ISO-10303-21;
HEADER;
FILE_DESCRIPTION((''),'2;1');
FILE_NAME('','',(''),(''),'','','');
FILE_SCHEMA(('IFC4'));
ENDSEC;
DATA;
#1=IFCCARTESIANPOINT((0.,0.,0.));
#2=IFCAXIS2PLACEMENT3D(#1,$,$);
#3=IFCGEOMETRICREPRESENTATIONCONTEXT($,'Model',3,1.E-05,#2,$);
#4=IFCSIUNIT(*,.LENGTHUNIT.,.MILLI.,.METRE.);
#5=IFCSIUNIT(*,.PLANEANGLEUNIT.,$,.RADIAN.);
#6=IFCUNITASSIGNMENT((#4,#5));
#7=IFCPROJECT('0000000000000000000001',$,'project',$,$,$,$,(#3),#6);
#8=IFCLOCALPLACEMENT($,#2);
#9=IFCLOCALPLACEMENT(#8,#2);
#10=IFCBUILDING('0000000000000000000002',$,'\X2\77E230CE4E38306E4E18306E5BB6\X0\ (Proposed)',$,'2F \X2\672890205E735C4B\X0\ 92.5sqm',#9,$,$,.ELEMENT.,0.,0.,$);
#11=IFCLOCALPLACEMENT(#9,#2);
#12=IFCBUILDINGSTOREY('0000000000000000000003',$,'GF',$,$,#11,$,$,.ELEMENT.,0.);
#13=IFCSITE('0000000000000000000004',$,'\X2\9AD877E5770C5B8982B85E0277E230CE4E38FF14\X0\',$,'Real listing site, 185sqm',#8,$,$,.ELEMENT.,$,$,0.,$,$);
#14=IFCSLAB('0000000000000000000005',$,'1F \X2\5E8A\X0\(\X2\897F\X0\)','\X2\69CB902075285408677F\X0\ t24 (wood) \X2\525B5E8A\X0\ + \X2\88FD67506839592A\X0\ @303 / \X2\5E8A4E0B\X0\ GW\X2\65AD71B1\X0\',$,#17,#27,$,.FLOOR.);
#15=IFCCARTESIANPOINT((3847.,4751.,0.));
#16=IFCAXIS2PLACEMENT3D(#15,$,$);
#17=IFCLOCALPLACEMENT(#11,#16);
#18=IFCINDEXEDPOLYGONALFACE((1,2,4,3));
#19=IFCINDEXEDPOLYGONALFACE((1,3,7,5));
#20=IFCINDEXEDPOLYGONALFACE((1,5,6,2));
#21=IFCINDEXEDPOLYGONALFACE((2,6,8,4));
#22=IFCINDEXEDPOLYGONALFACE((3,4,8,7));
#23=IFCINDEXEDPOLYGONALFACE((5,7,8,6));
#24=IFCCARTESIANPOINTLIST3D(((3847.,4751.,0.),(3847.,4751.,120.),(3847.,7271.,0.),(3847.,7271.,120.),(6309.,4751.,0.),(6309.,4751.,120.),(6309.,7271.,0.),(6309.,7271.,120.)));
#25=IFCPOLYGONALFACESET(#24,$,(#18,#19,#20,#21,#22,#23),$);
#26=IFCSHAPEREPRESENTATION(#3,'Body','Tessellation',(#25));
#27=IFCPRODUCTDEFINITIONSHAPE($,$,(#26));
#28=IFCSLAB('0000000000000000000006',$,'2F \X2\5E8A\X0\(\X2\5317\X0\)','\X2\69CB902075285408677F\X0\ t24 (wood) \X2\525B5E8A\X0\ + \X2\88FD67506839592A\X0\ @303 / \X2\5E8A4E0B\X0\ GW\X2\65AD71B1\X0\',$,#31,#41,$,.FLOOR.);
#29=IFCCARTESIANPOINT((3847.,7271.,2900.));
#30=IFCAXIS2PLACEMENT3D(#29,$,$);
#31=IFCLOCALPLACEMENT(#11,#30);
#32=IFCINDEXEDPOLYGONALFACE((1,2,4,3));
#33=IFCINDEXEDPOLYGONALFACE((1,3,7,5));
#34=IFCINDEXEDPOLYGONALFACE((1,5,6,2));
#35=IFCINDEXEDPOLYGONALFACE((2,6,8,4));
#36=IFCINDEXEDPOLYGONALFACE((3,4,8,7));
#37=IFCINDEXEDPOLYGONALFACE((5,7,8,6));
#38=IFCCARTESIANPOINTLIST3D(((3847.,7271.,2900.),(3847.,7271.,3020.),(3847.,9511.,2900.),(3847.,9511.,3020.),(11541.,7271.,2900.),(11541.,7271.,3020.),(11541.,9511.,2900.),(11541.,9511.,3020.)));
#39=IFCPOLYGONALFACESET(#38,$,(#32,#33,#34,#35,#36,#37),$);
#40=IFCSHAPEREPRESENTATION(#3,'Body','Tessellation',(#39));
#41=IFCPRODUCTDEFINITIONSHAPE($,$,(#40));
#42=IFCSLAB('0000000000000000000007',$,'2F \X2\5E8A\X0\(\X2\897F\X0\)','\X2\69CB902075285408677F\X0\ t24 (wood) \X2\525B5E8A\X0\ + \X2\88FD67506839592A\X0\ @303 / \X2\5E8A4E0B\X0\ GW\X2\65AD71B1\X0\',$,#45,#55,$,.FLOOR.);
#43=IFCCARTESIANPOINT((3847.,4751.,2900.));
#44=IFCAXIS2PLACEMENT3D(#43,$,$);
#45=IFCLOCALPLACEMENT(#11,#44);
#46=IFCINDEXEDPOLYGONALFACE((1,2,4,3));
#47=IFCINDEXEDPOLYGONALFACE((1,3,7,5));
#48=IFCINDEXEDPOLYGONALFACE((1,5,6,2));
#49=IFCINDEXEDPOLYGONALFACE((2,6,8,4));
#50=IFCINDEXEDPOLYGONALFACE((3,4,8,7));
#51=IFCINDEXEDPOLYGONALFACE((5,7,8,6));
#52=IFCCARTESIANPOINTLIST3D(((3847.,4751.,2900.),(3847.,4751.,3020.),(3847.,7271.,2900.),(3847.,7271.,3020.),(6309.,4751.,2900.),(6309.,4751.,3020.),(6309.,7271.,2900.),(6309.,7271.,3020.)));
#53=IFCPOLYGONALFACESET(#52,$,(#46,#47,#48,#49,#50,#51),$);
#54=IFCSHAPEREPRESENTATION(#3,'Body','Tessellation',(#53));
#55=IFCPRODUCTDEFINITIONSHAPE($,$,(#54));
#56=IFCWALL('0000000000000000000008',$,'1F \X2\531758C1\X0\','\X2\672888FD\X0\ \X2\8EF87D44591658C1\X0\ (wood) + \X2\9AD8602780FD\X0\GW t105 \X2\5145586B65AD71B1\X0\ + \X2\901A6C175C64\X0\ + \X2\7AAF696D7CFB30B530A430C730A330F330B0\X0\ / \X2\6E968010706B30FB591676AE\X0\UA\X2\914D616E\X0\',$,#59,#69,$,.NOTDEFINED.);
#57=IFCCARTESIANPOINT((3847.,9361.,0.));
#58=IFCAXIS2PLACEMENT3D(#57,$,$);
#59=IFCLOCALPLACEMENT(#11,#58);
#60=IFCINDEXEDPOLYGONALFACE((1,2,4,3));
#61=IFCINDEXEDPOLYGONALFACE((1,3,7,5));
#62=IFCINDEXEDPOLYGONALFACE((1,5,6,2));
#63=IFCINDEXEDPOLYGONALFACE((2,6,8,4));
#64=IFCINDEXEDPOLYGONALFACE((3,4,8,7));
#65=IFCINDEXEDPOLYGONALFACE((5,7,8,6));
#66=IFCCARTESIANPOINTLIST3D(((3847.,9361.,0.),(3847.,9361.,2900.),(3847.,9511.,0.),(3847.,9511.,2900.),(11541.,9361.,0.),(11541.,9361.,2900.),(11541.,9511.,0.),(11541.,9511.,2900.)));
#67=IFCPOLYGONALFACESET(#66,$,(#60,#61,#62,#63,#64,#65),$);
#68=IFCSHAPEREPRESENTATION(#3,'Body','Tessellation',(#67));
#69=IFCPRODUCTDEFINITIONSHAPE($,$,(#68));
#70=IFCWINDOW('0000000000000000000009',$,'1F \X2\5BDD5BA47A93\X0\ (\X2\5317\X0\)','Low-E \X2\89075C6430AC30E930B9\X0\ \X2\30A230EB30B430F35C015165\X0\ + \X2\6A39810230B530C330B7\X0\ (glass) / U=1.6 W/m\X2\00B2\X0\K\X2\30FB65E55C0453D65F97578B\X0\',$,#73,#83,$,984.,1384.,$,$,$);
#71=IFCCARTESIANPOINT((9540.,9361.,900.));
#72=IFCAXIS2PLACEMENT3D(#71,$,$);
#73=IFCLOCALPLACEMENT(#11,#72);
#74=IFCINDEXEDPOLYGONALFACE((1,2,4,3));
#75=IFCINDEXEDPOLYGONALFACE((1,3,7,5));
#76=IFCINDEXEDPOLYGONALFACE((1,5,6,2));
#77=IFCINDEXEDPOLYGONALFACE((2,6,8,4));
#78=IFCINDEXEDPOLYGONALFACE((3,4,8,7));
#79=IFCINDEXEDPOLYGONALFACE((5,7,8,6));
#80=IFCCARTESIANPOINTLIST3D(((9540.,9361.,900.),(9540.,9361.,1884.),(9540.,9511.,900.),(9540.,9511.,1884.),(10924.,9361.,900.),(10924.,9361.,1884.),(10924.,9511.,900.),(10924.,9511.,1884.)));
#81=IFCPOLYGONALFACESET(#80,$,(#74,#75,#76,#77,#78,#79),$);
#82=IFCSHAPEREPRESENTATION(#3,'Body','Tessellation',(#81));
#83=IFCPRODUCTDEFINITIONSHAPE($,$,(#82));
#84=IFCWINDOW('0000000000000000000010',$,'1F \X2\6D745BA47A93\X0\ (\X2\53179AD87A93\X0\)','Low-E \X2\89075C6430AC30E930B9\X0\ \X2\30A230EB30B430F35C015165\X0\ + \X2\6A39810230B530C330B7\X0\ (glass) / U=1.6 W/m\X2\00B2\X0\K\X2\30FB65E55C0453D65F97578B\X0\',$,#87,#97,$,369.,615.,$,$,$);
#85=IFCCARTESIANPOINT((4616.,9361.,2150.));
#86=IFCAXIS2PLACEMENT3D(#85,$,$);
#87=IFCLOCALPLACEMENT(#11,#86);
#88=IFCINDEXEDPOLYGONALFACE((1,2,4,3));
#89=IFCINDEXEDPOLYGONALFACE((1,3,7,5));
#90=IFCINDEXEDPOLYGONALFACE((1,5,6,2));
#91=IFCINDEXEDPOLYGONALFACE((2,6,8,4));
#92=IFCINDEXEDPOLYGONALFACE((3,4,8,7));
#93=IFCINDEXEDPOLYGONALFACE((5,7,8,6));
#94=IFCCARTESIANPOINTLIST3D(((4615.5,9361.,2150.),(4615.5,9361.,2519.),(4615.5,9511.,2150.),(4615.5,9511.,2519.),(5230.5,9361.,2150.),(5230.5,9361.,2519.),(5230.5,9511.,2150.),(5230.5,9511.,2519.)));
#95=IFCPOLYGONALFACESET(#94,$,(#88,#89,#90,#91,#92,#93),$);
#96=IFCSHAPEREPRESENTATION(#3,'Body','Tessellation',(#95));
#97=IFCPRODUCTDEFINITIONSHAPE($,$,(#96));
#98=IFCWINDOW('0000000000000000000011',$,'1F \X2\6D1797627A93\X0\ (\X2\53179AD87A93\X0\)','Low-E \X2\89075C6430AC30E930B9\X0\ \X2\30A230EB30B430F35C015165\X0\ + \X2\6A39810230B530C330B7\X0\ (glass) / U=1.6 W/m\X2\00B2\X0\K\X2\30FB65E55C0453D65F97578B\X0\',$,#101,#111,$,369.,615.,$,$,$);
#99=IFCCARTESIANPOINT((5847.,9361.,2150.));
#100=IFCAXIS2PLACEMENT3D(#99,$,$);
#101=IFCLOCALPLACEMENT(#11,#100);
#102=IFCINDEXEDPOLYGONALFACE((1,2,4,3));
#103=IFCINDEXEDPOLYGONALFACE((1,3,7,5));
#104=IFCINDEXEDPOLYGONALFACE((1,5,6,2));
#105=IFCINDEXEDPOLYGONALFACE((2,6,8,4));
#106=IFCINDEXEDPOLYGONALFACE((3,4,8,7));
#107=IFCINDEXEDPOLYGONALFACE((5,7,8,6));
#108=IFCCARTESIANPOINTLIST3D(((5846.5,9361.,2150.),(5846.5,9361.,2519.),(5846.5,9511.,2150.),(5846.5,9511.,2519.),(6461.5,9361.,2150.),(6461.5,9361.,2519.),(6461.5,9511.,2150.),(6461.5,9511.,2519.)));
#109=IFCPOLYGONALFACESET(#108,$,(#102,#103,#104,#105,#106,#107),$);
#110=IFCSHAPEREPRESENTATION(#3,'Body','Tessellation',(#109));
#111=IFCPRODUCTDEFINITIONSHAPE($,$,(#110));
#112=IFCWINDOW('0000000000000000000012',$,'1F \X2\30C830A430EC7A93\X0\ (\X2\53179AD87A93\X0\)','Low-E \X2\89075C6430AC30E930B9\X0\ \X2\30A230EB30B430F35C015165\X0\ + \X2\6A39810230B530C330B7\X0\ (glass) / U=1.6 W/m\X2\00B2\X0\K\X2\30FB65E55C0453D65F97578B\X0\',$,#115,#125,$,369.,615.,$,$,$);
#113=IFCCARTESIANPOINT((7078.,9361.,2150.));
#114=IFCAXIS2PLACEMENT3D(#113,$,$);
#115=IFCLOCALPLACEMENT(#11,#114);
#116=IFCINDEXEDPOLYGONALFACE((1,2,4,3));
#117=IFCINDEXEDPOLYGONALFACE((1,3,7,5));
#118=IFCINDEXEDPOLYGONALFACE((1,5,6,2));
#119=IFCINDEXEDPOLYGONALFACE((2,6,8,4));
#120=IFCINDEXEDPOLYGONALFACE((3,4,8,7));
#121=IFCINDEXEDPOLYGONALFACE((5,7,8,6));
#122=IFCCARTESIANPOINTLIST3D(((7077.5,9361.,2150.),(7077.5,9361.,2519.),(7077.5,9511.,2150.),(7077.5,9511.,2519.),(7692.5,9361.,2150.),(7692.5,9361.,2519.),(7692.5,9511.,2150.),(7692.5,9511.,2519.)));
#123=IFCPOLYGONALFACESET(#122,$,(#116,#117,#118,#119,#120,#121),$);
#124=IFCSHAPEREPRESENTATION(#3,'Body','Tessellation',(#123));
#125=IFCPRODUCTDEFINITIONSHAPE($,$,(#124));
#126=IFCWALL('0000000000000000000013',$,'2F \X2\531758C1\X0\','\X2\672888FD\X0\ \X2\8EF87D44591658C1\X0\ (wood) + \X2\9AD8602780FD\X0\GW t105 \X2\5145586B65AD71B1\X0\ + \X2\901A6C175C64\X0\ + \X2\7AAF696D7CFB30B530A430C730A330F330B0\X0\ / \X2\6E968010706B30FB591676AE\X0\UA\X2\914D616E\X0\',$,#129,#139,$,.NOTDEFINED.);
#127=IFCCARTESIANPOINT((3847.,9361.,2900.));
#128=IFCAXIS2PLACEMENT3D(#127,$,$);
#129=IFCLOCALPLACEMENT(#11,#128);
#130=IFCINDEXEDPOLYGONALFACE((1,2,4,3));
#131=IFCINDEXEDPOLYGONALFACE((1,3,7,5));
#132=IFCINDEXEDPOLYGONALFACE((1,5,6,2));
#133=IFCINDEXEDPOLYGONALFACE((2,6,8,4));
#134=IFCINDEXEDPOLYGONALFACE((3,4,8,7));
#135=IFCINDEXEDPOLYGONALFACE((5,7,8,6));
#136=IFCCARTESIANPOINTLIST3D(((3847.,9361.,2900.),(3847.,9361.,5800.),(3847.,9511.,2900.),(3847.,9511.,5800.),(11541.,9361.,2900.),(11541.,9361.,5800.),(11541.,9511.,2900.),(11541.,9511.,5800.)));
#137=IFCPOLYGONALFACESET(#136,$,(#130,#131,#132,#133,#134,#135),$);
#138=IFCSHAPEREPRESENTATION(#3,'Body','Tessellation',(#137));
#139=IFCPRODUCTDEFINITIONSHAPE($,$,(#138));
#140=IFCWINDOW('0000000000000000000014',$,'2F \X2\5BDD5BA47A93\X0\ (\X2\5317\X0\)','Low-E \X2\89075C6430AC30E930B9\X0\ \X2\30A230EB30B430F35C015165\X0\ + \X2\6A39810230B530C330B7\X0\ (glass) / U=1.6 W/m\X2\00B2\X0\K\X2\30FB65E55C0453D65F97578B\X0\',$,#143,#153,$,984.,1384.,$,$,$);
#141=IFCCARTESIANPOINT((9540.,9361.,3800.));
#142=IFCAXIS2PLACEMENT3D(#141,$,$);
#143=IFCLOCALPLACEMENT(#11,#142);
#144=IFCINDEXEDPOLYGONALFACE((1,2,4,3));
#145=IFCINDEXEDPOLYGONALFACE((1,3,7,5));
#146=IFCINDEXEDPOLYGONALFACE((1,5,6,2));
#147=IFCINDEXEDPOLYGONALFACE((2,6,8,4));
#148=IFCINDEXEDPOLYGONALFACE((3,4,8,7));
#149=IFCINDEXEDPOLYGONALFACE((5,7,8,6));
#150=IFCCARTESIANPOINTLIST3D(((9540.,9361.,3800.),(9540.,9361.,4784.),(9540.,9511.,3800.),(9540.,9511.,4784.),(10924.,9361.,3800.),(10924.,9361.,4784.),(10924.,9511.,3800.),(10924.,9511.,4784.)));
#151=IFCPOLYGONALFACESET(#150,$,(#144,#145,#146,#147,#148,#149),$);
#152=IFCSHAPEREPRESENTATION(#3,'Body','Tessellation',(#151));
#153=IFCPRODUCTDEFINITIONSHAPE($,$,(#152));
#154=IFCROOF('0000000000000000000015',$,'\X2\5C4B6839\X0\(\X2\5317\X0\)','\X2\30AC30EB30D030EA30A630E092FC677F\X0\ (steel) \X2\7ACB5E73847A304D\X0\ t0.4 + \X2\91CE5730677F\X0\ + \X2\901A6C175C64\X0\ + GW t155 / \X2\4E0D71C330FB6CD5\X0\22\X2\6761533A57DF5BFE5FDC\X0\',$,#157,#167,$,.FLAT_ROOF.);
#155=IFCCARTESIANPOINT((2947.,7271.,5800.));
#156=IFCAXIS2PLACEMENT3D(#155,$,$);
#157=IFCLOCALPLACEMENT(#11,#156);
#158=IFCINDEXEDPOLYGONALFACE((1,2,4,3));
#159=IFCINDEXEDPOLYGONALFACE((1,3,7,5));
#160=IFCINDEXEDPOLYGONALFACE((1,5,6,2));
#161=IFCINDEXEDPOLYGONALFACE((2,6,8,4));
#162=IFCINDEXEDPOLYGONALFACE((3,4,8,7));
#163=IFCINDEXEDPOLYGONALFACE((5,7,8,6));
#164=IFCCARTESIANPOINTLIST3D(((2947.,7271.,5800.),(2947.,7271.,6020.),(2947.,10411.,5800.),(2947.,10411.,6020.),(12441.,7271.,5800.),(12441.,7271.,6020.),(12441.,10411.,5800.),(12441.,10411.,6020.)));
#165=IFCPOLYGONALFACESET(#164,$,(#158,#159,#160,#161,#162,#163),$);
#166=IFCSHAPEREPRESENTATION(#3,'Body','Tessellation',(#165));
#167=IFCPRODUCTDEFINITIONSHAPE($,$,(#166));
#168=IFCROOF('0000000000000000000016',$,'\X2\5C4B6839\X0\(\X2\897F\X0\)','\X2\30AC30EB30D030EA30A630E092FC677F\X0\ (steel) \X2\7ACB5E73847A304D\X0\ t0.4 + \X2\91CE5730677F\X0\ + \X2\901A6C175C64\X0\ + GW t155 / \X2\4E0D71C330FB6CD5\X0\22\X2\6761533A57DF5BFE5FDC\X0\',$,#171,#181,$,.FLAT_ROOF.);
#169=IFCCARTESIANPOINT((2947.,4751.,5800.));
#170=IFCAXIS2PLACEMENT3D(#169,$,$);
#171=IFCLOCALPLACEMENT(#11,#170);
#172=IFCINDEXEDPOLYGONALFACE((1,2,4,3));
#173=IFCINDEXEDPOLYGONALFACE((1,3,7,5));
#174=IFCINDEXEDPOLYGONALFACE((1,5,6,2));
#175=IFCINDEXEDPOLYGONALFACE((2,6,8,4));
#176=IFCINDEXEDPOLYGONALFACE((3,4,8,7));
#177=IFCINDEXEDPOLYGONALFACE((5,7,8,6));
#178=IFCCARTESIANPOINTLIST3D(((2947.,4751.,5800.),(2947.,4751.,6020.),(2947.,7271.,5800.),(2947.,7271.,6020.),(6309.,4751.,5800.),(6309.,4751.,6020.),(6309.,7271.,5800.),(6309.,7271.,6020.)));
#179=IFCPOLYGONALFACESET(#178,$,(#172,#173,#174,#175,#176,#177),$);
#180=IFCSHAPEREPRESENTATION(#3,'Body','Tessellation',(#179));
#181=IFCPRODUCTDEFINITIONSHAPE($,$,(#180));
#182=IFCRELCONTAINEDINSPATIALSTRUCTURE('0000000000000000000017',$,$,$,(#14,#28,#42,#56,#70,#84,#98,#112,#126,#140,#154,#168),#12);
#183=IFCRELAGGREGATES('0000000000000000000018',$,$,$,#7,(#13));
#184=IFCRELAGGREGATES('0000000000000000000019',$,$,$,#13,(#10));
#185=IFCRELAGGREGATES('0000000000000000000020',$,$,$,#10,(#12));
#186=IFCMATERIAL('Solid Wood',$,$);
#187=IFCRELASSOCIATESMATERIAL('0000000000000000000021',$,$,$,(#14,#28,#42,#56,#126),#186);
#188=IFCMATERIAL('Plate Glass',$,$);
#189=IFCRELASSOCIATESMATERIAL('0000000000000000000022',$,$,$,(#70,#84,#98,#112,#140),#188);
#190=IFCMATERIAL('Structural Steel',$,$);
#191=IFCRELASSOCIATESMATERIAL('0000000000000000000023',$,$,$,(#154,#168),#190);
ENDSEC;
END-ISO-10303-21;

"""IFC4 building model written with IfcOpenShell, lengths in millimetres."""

from ifc_helpers import new_model, si_unit, frame, frame_2d, origin, place, context, project, spatial, rectangle, extrude, material, element, fill, save


model = new_model("IFC4")

# Units and contexts
model_context = context("Model", 3, precision=1e-05, world=origin())
ifc_project = project(units=[si_unit("LENGTHUNIT", "METRE", prefix="MILLI"), si_unit("PLANEANGLEUNIT", "RADIAN")], contexts=[model_context])

# Site, building, storey
site_placement = place(None, origin())
site = spatial("IfcSite", under=ifc_project, at=site_placement, Name="高知県安芸市矢ノ丸４", ObjectType="Real listing site, 185sqm", CompositionType="ELEMENT", RefElevation=0.0)
building_placement = place(site_placement, origin())
building = spatial("IfcBuilding", under=site, at=building_placement, Name="矢ノ丸の丘の家 (Proposed)", ObjectType="2F 木造平屋 92.5sqm", CompositionType="ELEMENT", ElevationOfRefHeight=0.0, ElevationOfTerrain=0.0)
storey_placement = place(building_placement, origin())
storey = spatial("IfcBuildingStorey", under=building, at=storey_placement, Name="GF", CompositionType="ELEMENT", Elevation=0.0)

# Slabs
ifc_material_1 = material(Name="Solid Wood")
slab_1_placement = place(storey_placement, frame((3847.0, 4751.0, 0.0)))
element("IfcSlab", 1, at=slab_1_placement, inside=storey, material=ifc_material_1, Name="1F 床(西)", Description="構造用合板 t24 (wood) 剛床 + 製材根太 @303 / 床下 GW断熱", PredefinedType="FLOOR", context=model_context, shape_type="SweptSolid", body=[
    extrude(rectangle(XDim=2462.0, YDim=2520.0, at=frame_2d((1231.0, 1260.0))), frame((3847.0, 4751.0, 0.0)), (0.0, 0.0, 1.0), 120.0),
])
slab_2_placement = place(storey_placement, frame((3847.0, 7271.0, 2900.0)))
element("IfcSlab", 2, at=slab_2_placement, inside=storey, material=ifc_material_1, Name="2F 床(北)", Description="構造用合板 t24 (wood) 剛床 + 製材根太 @303 / 床下 GW断熱", PredefinedType="FLOOR", context=model_context, shape_type="SweptSolid", body=[
    extrude(rectangle(XDim=7694.0, YDim=2240.0, at=frame_2d((3847.0, 1120.0))), frame((3847.0, 7271.0, 2900.0)), (0.0, 0.0, 1.0), 120.0),
])
slab_3_placement = place(storey_placement, frame((3847.0, 4751.0, 2900.0)))
element("IfcSlab", 3, at=slab_3_placement, inside=storey, material=ifc_material_1, Name="2F 床(西)", Description="構造用合板 t24 (wood) 剛床 + 製材根太 @303 / 床下 GW断熱", PredefinedType="FLOOR", context=model_context, shape_type="SweptSolid", body=[
    extrude(rectangle(XDim=2462.0, YDim=2520.0, at=frame_2d((1231.0, 1260.0))), frame((3847.0, 4751.0, 2900.0)), (0.0, 0.0, 1.0), 120.0),
])

# Wall, openings, windows
wall_1_placement = place(storey_placement, frame((3847.0, 9361.0, 0.0)))
wall_1 = element("IfcWall", 4, at=wall_1_placement, inside=storey, material=ifc_material_1, Name="1F 北壁", Description="木製 軸組外壁 (wood) + 高性能GW t105 充填断熱 + 通気層 + 窯業系サイディング / 準耐火・外皮UA配慮", PredefinedType="NOTDEFINED", context=model_context, shape_type="SweptSolid", body=[
    extrude(rectangle(XDim=7694.0, YDim=150.0, at=frame_2d((3847.0, 75.0))), frame((3847.0, 9361.0, 0.0)), (0.0, 0.0, 1.0), 2900.0),
])
opening_1_placement = place(storey_placement, frame((9540.0, 9361.0, 900.0)))
opening_1 = element("IfcOpeningElement", 5, at=opening_1_placement, cuts=wall_1, PredefinedType="NOTDEFINED", context=model_context, shape_type="SweptSolid", body=[
    extrude(rectangle(XDim=1384.0, YDim=150.0, at=frame_2d((692.0, 75.0))), frame((9540.0, 9361.0, 900.0)), (0.0, 0.0, 1.0), 984.0),
])
opening_2_placement = place(storey_placement, frame((4616.0, 9361.0, 2150.0)))
opening_2 = element("IfcOpeningElement", 6, at=opening_2_placement, cuts=wall_1, PredefinedType="NOTDEFINED", context=model_context, shape_type="SweptSolid", body=[
    extrude(rectangle(XDim=615.0, YDim=150.0, at=frame_2d((307.0, 75.0))), frame((4616.0, 9361.0, 2150.0)), (0.0, 0.0, 1.0), 369.0),
])
opening_3_placement = place(storey_placement, frame((5847.0, 9361.0, 2150.0)))
opening_3 = element("IfcOpeningElement", 7, at=opening_3_placement, cuts=wall_1, PredefinedType="NOTDEFINED", context=model_context, shape_type="SweptSolid", body=[
    extrude(rectangle(XDim=615.0, YDim=150.0, at=frame_2d((307.0, 75.0))), frame((5847.0, 9361.0, 2150.0)), (0.0, 0.0, 1.0), 369.0),
])
opening_4_placement = place(storey_placement, frame((7078.0, 9361.0, 2150.0)))
opening_4 = element("IfcOpeningElement", 8, at=opening_4_placement, cuts=wall_1, PredefinedType="NOTDEFINED", context=model_context, shape_type="SweptSolid", body=[
    extrude(rectangle(XDim=615.0, YDim=150.0, at=frame_2d((307.0, 75.0))), frame((7078.0, 9361.0, 2150.0)), (0.0, 0.0, 1.0), 369.0),
])
ifc_material_2 = material(Name="Plate Glass")
window_1_placement = place(storey_placement, frame((9540.0, 9361.0, 900.0)))
window_1 = element("IfcWindow", 9, at=window_1_placement, inside=storey, material=ifc_material_2, Name="1F 寝室窓 (北)", Description="Low-E 複層ガラス アルゴン封入 + 樹脂サッシ (glass) / U=1.6 W/m²K・日射取得型", OverallHeight=984.0, OverallWidth=1384.0, context=model_context, shape_type="SweptSolid", body=[
    extrude(rectangle(XDim=1384.0, YDim=150.0, at=frame_2d((692.0, 75.0))), frame((9540.0, 9361.0, 900.0)), (0.0, 0.0, 1.0), 984.0),
])
fill(opening_1, window_1)
window_2_placement = place(storey_placement, frame((4616.0, 9361.0, 2150.0)))
window_2 = element("IfcWindow", 10, at=window_2_placement, inside=storey, material=ifc_material_2, Name="1F 浴室窓 (北高窓)", Description="Low-E 複層ガラス アルゴン封入 + 樹脂サッシ (glass) / U=1.6 W/m²K・日射取得型", OverallHeight=369.0, OverallWidth=615.0, context=model_context, shape_type="SweptSolid", body=[
    extrude(rectangle(XDim=615.0, YDim=150.0, at=frame_2d((307.0, 75.0))), frame((4616.0, 9361.0, 2150.0)), (0.0, 0.0, 1.0), 369.0),
])
fill(opening_2, window_2)
window_3_placement = place(storey_placement, frame((5847.0, 9361.0, 2150.0)))
window_3 = element("IfcWindow", 11, at=window_3_placement, inside=storey, material=ifc_material_2, Name="1F 洗面窓 (北高窓)", Description="Low-E 複層ガラス アルゴン封入 + 樹脂サッシ (glass) / U=1.6 W/m²K・日射取得型", OverallHeight=369.0, OverallWidth=615.0, context=model_context, shape_type="SweptSolid", body=[
    extrude(rectangle(XDim=615.0, YDim=150.0, at=frame_2d((307.0, 75.0))), frame((5847.0, 9361.0, 2150.0)), (0.0, 0.0, 1.0), 369.0),
])
fill(opening_3, window_3)
window_4_placement = place(storey_placement, frame((7078.0, 9361.0, 2150.0)))
window_4 = element("IfcWindow", 12, at=window_4_placement, inside=storey, material=ifc_material_2, Name="1F トイレ窓 (北高窓)", Description="Low-E 複層ガラス アルゴン封入 + 樹脂サッシ (glass) / U=1.6 W/m²K・日射取得型", OverallHeight=369.0, OverallWidth=615.0, context=model_context, shape_type="SweptSolid", body=[
    extrude(rectangle(XDim=615.0, YDim=150.0, at=frame_2d((307.0, 75.0))), frame((7078.0, 9361.0, 2150.0)), (0.0, 0.0, 1.0), 369.0),
])
fill(opening_4, window_4)

# Wall, opening, window
wall_2_placement = place(storey_placement, frame((3847.0, 9361.0, 2900.0)))
wall_2 = element("IfcWall", 13, at=wall_2_placement, inside=storey, material=ifc_material_1, Name="2F 北壁", Description="木製 軸組外壁 (wood) + 高性能GW t105 充填断熱 + 通気層 + 窯業系サイディング / 準耐火・外皮UA配慮", PredefinedType="NOTDEFINED", context=model_context, shape_type="SweptSolid", body=[
    extrude(rectangle(XDim=7694.0, YDim=150.0, at=frame_2d((3847.0, 75.0))), frame((3847.0, 9361.0, 2900.0)), (0.0, 0.0, 1.0), 2900.0),
])
opening_5_placement = place(storey_placement, frame((9540.0, 9361.0, 3800.0)))
opening_5 = element("IfcOpeningElement", 14, at=opening_5_placement, cuts=wall_2, PredefinedType="NOTDEFINED", context=model_context, shape_type="SweptSolid", body=[
    extrude(rectangle(XDim=1384.0, YDim=150.0, at=frame_2d((692.0, 75.0))), frame((9540.0, 9361.0, 3800.0)), (0.0, 0.0, 1.0), 984.0),
])
window_5_placement = place(storey_placement, frame((9540.0, 9361.0, 3800.0)))
window_5 = element("IfcWindow", 15, at=window_5_placement, inside=storey, material=ifc_material_2, Name="2F 寝室窓 (北)", Description="Low-E 複層ガラス アルゴン封入 + 樹脂サッシ (glass) / U=1.6 W/m²K・日射取得型", OverallHeight=984.0, OverallWidth=1384.0, context=model_context, shape_type="SweptSolid", body=[
    extrude(rectangle(XDim=1384.0, YDim=150.0, at=frame_2d((692.0, 75.0))), frame((9540.0, 9361.0, 3800.0)), (0.0, 0.0, 1.0), 984.0),
])
fill(opening_5, window_5)

# Roofs
ifc_material_3 = material(Name="Structural Steel")
for number, where, name in (
    (16, (2947.0, 7271.0, 5800.0), "屋根(北)"),
):
    element("IfcRoof", number, at=place(storey_placement, frame(where)), inside=storey, material=ifc_material_3, Name=name, Description="ガルバリウム鋼板 (steel) 立平葺き t0.4 + 野地板 + 通気層 + GW t155 / 不燃・法22条区域対応", PredefinedType="FLAT_ROOF", context=model_context, shape_type="SweptSolid", body=[
        extrude(rectangle(XDim=9494.0, YDim=3140.0, at=frame_2d((4747.0, 1570.0))), frame((2947.0, 7271.0, 5800.0)), (0.0, 0.0, 1.0), 220.0),
    ])
roof_placement = place(storey_placement, frame((2947.0, 4751.0, 5800.0)))
element("IfcRoof", 17, at=roof_placement, inside=storey, material=ifc_material_3, Name="屋根(西)", Description="ガルバリウム鋼板 (steel) 立平葺き t0.4 + 野地板 + 通気層 + GW t155 / 不燃・法22条区域対応", PredefinedType="FLAT_ROOF", context=model_context, shape_type="SweptSolid", body=[
    extrude(rectangle(XDim=3362.0, YDim=2520.0, at=frame_2d((1681.0, 1260.0))), frame((2947.0, 4751.0, 5800.0)), (0.0, 0.0, 1.0), 220.0),
])

save(model, "model.ifc")
